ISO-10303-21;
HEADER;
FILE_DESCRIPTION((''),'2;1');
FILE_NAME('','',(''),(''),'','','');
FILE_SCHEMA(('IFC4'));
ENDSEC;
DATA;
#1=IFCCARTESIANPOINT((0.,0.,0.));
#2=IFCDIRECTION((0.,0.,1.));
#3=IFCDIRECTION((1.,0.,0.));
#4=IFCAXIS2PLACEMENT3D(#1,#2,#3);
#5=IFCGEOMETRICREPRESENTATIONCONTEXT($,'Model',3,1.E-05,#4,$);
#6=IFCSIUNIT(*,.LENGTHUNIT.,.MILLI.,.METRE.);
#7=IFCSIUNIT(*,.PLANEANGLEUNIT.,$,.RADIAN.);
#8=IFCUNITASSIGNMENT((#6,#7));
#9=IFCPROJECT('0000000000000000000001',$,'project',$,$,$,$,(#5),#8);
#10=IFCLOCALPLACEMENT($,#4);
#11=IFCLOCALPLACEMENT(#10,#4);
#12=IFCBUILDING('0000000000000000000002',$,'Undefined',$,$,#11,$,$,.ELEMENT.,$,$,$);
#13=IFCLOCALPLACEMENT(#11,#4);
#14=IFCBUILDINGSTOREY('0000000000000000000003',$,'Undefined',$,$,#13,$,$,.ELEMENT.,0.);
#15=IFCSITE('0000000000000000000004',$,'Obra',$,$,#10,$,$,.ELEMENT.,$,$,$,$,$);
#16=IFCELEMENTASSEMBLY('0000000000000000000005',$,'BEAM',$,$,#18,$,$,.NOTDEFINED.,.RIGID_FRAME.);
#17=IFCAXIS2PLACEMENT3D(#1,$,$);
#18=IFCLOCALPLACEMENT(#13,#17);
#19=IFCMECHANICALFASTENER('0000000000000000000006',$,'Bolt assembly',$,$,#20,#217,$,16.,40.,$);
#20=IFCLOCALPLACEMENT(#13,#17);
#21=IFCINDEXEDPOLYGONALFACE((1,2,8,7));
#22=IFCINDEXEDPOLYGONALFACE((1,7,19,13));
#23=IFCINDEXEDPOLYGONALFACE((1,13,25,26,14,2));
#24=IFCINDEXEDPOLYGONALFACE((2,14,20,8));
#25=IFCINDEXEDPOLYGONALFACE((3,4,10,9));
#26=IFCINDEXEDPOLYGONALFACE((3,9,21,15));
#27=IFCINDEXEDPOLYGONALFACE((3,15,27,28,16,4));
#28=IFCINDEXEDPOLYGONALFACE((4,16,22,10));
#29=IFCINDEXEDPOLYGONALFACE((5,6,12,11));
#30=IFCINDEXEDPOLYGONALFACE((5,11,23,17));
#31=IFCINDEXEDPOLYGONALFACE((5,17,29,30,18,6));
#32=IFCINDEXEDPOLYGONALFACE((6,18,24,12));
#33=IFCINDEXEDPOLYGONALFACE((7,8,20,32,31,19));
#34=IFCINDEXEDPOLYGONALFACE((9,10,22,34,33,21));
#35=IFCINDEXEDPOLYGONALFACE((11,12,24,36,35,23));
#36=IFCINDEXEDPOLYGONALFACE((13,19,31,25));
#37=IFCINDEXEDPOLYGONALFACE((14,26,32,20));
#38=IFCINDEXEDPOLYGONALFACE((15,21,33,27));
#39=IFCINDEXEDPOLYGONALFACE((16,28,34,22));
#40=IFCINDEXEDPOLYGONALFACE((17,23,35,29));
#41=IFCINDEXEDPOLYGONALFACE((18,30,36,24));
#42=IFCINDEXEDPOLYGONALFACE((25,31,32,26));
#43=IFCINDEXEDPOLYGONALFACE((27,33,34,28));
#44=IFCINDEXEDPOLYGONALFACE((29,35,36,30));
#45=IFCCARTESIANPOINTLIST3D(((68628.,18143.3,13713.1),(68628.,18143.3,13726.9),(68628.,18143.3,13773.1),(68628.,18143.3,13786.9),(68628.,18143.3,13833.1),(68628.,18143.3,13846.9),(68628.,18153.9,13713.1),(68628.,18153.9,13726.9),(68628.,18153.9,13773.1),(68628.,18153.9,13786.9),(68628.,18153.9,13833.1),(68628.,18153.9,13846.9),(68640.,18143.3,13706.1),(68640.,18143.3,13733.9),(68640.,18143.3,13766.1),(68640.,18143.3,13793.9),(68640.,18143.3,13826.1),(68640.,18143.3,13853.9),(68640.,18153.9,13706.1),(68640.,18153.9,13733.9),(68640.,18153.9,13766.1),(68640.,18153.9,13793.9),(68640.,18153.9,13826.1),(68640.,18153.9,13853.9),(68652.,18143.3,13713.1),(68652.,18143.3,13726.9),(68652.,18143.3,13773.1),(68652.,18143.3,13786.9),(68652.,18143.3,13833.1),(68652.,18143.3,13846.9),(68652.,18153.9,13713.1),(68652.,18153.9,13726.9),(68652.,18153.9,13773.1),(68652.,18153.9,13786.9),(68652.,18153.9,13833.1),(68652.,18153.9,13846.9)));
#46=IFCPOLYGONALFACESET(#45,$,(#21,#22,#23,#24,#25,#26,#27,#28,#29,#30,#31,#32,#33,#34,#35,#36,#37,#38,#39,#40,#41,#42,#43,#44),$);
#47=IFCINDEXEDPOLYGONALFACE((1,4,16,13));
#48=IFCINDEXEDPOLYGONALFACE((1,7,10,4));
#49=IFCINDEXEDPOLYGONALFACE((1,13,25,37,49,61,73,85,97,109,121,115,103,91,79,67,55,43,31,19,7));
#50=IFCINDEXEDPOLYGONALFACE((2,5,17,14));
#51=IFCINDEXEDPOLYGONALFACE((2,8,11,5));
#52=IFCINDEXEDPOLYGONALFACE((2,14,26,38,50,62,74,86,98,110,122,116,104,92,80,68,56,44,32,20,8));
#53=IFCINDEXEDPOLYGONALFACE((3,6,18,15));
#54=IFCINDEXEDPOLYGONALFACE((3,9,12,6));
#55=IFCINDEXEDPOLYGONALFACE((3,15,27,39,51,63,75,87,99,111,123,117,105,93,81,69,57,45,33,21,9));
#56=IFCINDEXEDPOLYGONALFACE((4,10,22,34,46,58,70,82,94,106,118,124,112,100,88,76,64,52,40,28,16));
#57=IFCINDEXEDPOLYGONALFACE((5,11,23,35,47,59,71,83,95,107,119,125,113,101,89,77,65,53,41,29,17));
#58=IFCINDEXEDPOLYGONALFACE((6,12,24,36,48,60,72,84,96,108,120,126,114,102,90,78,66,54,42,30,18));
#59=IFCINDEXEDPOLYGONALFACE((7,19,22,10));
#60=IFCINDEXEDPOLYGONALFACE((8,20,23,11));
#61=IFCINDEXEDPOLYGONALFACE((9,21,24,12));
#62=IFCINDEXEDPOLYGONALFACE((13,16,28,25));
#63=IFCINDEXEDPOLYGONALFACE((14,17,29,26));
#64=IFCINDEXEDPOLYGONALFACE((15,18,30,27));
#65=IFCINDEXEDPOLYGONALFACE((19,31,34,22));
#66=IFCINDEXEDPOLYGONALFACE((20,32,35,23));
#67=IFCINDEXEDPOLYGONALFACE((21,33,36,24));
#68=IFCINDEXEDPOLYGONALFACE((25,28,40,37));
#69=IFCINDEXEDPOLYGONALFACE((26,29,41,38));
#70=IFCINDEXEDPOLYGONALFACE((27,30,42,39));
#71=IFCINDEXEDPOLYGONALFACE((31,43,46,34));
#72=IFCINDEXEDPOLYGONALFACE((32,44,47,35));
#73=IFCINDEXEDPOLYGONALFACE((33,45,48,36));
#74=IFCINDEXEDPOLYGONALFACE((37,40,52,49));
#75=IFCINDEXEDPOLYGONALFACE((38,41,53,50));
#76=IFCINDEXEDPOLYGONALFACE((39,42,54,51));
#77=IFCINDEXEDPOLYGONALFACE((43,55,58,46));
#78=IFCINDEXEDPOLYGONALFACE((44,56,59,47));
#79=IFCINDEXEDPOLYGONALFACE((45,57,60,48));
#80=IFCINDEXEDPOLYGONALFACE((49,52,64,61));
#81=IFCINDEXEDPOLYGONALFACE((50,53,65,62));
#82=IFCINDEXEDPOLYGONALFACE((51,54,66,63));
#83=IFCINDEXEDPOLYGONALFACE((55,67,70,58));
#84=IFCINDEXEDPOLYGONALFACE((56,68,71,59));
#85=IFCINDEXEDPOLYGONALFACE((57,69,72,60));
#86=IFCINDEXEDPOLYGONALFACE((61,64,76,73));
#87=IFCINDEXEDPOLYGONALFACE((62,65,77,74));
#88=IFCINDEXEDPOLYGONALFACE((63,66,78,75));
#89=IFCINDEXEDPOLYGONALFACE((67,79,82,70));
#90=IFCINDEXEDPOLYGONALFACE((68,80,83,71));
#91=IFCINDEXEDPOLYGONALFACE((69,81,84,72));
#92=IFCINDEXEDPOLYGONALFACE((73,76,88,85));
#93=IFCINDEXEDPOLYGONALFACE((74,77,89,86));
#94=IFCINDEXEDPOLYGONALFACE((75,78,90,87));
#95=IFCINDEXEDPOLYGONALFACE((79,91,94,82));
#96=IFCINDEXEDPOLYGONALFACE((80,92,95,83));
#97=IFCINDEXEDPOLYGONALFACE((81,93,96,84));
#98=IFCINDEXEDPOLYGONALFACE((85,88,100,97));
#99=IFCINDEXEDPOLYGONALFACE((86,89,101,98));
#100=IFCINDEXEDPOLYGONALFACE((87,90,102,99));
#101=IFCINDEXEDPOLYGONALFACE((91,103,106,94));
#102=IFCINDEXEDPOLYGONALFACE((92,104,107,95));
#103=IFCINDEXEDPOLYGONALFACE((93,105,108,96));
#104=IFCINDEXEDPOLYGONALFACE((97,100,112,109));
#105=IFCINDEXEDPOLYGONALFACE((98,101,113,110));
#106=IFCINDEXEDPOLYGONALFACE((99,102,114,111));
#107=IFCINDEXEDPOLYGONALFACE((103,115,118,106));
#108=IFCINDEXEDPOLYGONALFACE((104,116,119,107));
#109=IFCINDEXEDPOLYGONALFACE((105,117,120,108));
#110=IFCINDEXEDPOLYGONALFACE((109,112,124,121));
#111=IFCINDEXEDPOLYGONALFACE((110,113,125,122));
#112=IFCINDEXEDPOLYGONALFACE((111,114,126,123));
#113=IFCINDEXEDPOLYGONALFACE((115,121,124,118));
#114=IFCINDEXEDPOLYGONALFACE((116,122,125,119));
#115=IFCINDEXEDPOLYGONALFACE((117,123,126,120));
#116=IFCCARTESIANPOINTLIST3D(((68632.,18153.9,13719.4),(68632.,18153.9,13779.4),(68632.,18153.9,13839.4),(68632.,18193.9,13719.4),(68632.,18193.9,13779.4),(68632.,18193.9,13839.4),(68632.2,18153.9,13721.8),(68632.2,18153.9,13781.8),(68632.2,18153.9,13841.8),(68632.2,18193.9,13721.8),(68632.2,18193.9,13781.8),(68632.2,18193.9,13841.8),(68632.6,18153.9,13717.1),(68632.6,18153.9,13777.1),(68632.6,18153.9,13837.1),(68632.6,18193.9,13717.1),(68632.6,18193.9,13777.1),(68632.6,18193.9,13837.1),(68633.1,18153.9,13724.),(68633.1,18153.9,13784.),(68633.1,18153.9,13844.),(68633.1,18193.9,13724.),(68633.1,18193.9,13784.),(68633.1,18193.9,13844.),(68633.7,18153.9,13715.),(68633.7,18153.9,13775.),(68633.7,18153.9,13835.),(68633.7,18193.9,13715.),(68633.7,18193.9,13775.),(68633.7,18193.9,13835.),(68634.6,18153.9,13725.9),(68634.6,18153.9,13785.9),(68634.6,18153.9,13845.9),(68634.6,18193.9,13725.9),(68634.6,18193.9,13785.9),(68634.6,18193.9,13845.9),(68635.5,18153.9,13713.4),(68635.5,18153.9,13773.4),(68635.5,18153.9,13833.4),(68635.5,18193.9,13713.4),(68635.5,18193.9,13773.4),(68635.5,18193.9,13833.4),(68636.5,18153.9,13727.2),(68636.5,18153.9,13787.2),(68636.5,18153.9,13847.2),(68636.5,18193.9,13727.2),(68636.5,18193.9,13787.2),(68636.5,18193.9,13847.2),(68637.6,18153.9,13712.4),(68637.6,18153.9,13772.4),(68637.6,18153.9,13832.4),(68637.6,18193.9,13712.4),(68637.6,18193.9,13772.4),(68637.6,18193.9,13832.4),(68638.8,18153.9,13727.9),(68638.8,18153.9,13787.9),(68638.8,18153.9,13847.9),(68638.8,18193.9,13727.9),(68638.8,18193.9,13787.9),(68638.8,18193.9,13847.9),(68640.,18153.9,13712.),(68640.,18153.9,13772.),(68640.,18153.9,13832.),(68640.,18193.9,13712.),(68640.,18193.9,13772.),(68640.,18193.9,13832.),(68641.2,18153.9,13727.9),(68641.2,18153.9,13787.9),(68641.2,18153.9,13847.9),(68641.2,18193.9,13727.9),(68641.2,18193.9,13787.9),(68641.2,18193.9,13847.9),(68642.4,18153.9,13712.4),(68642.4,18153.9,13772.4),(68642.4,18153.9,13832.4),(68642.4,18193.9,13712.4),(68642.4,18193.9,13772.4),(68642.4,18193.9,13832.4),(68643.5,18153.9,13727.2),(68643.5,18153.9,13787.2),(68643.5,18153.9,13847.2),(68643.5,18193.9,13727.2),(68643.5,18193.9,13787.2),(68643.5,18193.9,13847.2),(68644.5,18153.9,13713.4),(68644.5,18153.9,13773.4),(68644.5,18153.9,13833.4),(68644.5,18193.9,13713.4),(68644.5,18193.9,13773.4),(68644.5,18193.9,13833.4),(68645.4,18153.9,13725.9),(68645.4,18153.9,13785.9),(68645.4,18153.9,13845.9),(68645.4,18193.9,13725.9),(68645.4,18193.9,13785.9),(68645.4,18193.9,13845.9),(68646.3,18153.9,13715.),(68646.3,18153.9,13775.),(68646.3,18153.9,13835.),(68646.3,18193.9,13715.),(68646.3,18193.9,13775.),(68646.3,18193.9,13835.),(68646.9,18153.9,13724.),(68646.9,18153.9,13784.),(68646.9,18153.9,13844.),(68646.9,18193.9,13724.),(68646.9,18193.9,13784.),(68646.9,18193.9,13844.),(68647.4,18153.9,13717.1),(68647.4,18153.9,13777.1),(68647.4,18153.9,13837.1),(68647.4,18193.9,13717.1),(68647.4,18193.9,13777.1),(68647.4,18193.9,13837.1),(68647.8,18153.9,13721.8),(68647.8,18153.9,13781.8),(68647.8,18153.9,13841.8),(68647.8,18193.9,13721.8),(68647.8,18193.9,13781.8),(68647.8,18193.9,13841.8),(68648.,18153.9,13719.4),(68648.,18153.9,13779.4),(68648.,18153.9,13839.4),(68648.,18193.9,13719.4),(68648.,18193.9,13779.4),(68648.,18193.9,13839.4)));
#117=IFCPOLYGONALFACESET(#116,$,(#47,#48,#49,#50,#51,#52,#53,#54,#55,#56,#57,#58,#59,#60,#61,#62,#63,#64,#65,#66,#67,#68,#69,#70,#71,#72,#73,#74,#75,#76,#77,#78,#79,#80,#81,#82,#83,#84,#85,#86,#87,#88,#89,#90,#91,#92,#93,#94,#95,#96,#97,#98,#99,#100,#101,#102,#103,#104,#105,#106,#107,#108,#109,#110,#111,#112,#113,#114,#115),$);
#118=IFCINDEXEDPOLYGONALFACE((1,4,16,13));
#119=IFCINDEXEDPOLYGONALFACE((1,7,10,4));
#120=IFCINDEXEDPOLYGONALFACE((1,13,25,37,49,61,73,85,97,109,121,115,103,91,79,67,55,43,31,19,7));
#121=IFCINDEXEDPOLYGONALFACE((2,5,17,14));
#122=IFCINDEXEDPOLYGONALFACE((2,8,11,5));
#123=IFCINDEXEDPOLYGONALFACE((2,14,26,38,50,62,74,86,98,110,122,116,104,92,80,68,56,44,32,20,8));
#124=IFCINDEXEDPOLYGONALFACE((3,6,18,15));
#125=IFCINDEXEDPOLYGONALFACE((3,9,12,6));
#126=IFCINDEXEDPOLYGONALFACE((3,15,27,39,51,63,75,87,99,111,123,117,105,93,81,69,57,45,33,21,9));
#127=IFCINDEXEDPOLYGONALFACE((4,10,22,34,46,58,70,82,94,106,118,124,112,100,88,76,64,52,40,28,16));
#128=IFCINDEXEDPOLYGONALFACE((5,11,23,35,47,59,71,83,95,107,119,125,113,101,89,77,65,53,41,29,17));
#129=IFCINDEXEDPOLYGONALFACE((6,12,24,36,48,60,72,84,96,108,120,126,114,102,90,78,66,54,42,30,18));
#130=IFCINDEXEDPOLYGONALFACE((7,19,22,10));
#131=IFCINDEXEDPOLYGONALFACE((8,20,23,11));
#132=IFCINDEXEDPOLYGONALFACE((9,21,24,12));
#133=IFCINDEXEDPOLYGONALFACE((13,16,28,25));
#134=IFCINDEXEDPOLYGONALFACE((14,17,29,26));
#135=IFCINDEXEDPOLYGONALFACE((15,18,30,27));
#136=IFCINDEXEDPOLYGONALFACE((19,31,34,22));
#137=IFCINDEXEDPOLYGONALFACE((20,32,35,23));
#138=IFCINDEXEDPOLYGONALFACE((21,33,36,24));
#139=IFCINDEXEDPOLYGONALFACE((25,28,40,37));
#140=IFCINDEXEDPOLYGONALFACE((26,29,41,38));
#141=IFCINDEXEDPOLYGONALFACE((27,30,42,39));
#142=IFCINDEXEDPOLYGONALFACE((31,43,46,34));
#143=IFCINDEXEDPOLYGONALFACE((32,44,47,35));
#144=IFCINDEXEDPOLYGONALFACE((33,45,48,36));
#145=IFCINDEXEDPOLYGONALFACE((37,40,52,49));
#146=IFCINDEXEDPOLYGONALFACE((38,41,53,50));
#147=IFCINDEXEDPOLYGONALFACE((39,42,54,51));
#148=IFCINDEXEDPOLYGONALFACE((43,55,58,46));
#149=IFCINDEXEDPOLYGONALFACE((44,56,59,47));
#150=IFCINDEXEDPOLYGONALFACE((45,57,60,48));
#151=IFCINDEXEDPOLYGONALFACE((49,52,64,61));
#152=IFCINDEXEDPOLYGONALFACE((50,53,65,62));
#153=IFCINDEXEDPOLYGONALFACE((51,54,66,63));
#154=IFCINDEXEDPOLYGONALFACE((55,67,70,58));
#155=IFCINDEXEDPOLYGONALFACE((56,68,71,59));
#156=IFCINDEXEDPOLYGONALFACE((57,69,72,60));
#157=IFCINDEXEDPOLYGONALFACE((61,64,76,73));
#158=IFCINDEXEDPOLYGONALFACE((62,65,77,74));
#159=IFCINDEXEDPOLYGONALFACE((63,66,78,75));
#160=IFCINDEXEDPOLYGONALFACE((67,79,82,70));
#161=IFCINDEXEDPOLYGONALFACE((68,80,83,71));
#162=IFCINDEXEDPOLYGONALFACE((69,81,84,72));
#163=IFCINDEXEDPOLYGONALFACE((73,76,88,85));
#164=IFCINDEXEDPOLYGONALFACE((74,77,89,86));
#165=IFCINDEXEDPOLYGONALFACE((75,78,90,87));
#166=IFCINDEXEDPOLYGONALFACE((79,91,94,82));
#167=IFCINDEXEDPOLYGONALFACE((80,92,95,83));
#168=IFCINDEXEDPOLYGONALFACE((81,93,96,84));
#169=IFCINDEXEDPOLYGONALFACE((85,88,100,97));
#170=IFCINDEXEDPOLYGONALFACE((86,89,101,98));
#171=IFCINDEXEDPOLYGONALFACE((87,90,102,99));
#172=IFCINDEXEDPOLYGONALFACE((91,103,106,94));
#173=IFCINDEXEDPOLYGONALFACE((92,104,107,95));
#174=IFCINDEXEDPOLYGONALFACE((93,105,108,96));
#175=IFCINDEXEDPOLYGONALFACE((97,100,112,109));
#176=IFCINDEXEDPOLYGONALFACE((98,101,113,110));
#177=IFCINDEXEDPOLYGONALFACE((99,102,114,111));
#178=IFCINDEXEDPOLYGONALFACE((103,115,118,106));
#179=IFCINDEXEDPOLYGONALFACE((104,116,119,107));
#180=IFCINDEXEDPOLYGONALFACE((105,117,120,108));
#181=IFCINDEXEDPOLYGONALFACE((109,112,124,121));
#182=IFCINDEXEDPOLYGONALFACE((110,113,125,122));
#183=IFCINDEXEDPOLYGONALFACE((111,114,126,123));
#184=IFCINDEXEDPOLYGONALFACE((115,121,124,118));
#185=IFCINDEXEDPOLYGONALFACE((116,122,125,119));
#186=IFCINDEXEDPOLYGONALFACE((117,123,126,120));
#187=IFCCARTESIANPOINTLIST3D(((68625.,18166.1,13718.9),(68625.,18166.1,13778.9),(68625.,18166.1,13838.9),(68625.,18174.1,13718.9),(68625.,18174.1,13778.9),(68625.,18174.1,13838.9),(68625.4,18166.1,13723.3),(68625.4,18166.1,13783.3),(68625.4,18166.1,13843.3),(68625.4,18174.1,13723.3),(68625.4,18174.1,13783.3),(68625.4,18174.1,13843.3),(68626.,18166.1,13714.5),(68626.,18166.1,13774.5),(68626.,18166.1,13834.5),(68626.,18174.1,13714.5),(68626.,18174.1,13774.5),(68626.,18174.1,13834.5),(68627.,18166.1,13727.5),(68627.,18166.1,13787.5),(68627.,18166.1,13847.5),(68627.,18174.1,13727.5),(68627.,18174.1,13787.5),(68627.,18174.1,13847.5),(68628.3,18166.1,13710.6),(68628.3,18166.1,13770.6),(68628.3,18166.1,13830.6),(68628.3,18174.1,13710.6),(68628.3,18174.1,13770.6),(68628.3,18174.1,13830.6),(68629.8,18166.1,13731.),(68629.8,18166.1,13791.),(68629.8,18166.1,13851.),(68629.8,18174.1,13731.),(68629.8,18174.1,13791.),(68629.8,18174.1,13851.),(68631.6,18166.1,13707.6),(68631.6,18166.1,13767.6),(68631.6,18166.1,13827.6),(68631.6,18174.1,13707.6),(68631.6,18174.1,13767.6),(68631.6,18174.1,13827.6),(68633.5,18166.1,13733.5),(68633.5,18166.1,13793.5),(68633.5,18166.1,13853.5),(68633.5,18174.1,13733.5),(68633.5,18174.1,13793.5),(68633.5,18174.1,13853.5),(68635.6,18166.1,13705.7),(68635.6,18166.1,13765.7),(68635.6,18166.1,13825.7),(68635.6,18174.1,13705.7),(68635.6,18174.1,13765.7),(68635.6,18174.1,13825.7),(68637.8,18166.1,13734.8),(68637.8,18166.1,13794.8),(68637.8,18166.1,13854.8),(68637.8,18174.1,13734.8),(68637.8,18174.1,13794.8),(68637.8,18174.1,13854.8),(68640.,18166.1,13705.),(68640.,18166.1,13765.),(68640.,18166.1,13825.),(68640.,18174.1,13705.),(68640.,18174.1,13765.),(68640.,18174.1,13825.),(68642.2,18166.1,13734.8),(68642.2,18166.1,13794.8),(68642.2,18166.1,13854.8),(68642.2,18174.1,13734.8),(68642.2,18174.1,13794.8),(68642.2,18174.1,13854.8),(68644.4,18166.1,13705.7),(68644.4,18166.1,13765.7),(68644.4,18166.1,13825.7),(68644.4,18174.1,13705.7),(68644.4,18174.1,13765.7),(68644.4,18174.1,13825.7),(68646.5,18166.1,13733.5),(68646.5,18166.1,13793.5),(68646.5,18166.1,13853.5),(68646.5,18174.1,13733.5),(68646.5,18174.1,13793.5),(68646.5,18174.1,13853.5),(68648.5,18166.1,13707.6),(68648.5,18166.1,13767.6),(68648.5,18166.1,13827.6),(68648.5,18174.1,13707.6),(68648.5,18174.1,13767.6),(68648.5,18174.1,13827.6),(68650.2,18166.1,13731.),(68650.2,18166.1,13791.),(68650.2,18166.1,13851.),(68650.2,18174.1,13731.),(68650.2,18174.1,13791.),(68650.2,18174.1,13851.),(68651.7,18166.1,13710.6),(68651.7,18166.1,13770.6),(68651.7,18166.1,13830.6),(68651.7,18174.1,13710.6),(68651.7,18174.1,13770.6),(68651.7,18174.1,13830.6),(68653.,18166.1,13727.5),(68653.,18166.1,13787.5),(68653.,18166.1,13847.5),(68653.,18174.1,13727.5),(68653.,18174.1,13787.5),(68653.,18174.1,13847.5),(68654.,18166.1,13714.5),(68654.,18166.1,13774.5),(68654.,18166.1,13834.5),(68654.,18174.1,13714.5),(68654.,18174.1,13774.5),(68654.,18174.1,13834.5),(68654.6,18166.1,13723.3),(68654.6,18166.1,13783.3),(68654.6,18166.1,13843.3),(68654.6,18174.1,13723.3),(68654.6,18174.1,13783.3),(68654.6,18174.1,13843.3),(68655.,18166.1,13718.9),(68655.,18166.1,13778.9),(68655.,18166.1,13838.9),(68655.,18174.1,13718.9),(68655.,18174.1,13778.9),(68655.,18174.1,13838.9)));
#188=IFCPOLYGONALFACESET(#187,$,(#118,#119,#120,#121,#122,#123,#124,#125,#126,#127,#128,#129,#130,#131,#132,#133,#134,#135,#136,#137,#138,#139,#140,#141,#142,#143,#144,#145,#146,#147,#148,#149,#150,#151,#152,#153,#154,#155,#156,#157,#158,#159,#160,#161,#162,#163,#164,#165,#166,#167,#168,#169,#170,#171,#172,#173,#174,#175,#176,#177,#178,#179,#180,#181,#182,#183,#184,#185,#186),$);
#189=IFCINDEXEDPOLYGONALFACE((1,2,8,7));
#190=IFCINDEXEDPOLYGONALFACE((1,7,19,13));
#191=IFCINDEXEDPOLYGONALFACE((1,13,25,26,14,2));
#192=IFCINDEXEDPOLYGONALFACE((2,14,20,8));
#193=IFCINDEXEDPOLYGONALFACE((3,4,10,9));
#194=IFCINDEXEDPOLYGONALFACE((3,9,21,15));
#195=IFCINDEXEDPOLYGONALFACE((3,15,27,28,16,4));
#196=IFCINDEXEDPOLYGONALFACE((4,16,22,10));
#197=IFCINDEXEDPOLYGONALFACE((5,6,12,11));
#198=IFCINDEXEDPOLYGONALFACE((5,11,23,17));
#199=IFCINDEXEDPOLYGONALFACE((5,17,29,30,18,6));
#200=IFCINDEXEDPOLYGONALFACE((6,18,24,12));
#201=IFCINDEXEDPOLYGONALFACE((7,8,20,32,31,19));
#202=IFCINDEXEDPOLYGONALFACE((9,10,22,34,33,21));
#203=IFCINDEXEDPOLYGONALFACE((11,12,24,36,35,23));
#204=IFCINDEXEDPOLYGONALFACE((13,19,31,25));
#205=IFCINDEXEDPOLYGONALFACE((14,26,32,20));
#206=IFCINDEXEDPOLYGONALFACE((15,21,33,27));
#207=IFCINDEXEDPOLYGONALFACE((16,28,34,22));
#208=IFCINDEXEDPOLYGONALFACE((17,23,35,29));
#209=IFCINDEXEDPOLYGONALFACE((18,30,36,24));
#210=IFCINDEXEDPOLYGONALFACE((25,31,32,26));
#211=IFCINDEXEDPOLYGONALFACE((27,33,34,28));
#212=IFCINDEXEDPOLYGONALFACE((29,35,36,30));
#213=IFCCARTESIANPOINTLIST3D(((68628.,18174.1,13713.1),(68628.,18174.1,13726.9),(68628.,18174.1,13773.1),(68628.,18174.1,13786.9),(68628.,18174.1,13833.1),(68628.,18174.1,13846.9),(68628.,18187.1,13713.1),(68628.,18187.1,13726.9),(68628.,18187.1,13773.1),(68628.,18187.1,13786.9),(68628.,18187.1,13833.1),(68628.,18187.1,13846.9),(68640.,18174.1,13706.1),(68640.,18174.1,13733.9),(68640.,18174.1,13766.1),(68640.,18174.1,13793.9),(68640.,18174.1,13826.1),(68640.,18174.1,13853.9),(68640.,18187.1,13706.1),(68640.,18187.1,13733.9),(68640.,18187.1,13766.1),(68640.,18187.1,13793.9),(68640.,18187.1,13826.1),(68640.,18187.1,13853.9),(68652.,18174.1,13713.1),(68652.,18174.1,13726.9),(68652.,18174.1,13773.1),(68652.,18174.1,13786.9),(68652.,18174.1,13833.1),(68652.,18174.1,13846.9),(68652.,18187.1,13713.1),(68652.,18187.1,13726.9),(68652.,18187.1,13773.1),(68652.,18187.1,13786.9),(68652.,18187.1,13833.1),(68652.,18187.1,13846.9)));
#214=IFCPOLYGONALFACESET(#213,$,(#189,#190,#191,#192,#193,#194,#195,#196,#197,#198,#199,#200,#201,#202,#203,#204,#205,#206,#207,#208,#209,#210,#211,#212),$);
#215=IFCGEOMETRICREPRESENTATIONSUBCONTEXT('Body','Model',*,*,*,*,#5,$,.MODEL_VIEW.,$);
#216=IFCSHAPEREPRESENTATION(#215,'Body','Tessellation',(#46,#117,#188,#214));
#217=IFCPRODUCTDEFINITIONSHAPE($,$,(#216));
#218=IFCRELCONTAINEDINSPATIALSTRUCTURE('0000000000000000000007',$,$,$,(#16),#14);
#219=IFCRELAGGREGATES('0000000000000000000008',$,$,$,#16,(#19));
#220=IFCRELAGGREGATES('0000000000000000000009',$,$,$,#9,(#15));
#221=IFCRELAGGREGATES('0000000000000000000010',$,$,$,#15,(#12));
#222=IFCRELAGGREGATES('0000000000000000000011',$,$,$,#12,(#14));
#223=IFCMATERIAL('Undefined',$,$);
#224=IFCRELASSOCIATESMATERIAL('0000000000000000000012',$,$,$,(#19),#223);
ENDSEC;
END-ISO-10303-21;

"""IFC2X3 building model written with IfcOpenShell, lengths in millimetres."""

from ifc_helpers import new_model, si_unit, frame, origin_with_axes, origin_2d_with_axis, place, context, subcontext, project, spatial, polyline, circle, outline, extrude, source, transform, mapped, material, element, aggregate, save


model = new_model("IFC2X3")

# Units and contexts
model_context = context("Model", 3, precision=1e-05, world=origin_with_axes())
body_context = subcontext(model_context, "Body", "Model", "MODEL_VIEW")
ifc_project = project(units=[si_unit("LENGTHUNIT", "METRE", prefix="MILLI"), si_unit("PLANEANGLEUNIT", "RADIAN")], contexts=[model_context])

# Site, building, storey
site_placement = place(None, origin_with_axes())
site = spatial("IfcSite", under=ifc_project, at=site_placement, Name="Obra", CompositionType="ELEMENT")
building_placement = place(site_placement, origin_with_axes())
building = spatial("IfcBuilding", under=site, at=building_placement, Name="Undefined", CompositionType="ELEMENT")
storey_placement = place(building_placement, origin_with_axes())
storey = spatial("IfcBuildingStorey", under=building, at=storey_placement, Name="Undefined", CompositionType="ELEMENT", Elevation=0.0)

# Element assembly
assembly_1_placement = place(storey_placement, origin_with_axes())
assembly_1 = element("IfcElementAssembly", 1, at=assembly_1_placement, inside=storey, Name="BEAM", AssemblyPlace="NOTDEFINED", PredefinedType="RIGID_FRAME")

# Mechanical fastener
ifc_material_1 = material(Name="Undefined")
shared_shape_1 = source(origin_with_axes(), body_context, "Body", "SweptSolid", [
    extrude(outline(polyline([(13.9, 0.0), (6.9, 12.0), (-6.9, 12.0), (-13.9, 0.0), (-6.9, -12.0), (6.9, -12.0), (13.9, 0.0)])), frame((0.0, -19.7, 0.0), z_axis=(0.0, 1.0, 0.0), x_axis=(1.0, 0.0, 0.0)), (0.0, 0.0, 1.0), 10.6),
    extrude(circle(Radius=8.0, at=origin_2d_with_axis()), frame((0.0, -9.1, 0.0), z_axis=(0.0, 1.0, 0.0), x_axis=(1.0, 0.0, 0.0)), (0.0, 0.0, 1.0), 40.0),
    extrude(circle(Radius=15.0, at=origin_2d_with_axis()), frame((0.0, 3.1, 0.0), z_axis=(0.0, 1.0, 0.0), x_axis=(1.0, 0.0, 0.0)), (0.0, 0.0, 1.0), 8.0),
    extrude(outline(polyline([(13.9, 0.0), (6.9, 12.0), (-6.9, 12.0), (-13.9, 0.0), (-6.9, -12.0), (6.9, -12.0), (13.9, 0.0)])), frame((0.0, 11.1, 0.0), z_axis=(0.0, 1.0, 0.0), x_axis=(1.0, 0.0, 0.0)), (0.0, 0.0, 1.0), 13.0),
])
mechanical_fastener_placement = place(assembly_1_placement, frame((68590.0, 18163.0, 13890.2), z_axis=(1.0, 0.0, 0.0), x_axis=(0.0, 0.0, -1.0)))
mechanical_fastener = element("IfcMechanicalFastener", 2, at=mechanical_fastener_placement, material=ifc_material_1, Name="Bolt assembly", NominalDiameter=16.0, NominalLength=40.0, context=body_context, shape_type="MappedRepresentation", body=[
    mapped(shared_shape_1, transform((170.2, 0.0, 50.0))),
    mapped(shared_shape_1, transform((110.2, 0.0, 50.0))),
    mapped(shared_shape_1, transform((50.2, 0.0, 50.0))),
])
aggregate(assembly_1, [mechanical_fastener])

save(model, "model.ifc")
